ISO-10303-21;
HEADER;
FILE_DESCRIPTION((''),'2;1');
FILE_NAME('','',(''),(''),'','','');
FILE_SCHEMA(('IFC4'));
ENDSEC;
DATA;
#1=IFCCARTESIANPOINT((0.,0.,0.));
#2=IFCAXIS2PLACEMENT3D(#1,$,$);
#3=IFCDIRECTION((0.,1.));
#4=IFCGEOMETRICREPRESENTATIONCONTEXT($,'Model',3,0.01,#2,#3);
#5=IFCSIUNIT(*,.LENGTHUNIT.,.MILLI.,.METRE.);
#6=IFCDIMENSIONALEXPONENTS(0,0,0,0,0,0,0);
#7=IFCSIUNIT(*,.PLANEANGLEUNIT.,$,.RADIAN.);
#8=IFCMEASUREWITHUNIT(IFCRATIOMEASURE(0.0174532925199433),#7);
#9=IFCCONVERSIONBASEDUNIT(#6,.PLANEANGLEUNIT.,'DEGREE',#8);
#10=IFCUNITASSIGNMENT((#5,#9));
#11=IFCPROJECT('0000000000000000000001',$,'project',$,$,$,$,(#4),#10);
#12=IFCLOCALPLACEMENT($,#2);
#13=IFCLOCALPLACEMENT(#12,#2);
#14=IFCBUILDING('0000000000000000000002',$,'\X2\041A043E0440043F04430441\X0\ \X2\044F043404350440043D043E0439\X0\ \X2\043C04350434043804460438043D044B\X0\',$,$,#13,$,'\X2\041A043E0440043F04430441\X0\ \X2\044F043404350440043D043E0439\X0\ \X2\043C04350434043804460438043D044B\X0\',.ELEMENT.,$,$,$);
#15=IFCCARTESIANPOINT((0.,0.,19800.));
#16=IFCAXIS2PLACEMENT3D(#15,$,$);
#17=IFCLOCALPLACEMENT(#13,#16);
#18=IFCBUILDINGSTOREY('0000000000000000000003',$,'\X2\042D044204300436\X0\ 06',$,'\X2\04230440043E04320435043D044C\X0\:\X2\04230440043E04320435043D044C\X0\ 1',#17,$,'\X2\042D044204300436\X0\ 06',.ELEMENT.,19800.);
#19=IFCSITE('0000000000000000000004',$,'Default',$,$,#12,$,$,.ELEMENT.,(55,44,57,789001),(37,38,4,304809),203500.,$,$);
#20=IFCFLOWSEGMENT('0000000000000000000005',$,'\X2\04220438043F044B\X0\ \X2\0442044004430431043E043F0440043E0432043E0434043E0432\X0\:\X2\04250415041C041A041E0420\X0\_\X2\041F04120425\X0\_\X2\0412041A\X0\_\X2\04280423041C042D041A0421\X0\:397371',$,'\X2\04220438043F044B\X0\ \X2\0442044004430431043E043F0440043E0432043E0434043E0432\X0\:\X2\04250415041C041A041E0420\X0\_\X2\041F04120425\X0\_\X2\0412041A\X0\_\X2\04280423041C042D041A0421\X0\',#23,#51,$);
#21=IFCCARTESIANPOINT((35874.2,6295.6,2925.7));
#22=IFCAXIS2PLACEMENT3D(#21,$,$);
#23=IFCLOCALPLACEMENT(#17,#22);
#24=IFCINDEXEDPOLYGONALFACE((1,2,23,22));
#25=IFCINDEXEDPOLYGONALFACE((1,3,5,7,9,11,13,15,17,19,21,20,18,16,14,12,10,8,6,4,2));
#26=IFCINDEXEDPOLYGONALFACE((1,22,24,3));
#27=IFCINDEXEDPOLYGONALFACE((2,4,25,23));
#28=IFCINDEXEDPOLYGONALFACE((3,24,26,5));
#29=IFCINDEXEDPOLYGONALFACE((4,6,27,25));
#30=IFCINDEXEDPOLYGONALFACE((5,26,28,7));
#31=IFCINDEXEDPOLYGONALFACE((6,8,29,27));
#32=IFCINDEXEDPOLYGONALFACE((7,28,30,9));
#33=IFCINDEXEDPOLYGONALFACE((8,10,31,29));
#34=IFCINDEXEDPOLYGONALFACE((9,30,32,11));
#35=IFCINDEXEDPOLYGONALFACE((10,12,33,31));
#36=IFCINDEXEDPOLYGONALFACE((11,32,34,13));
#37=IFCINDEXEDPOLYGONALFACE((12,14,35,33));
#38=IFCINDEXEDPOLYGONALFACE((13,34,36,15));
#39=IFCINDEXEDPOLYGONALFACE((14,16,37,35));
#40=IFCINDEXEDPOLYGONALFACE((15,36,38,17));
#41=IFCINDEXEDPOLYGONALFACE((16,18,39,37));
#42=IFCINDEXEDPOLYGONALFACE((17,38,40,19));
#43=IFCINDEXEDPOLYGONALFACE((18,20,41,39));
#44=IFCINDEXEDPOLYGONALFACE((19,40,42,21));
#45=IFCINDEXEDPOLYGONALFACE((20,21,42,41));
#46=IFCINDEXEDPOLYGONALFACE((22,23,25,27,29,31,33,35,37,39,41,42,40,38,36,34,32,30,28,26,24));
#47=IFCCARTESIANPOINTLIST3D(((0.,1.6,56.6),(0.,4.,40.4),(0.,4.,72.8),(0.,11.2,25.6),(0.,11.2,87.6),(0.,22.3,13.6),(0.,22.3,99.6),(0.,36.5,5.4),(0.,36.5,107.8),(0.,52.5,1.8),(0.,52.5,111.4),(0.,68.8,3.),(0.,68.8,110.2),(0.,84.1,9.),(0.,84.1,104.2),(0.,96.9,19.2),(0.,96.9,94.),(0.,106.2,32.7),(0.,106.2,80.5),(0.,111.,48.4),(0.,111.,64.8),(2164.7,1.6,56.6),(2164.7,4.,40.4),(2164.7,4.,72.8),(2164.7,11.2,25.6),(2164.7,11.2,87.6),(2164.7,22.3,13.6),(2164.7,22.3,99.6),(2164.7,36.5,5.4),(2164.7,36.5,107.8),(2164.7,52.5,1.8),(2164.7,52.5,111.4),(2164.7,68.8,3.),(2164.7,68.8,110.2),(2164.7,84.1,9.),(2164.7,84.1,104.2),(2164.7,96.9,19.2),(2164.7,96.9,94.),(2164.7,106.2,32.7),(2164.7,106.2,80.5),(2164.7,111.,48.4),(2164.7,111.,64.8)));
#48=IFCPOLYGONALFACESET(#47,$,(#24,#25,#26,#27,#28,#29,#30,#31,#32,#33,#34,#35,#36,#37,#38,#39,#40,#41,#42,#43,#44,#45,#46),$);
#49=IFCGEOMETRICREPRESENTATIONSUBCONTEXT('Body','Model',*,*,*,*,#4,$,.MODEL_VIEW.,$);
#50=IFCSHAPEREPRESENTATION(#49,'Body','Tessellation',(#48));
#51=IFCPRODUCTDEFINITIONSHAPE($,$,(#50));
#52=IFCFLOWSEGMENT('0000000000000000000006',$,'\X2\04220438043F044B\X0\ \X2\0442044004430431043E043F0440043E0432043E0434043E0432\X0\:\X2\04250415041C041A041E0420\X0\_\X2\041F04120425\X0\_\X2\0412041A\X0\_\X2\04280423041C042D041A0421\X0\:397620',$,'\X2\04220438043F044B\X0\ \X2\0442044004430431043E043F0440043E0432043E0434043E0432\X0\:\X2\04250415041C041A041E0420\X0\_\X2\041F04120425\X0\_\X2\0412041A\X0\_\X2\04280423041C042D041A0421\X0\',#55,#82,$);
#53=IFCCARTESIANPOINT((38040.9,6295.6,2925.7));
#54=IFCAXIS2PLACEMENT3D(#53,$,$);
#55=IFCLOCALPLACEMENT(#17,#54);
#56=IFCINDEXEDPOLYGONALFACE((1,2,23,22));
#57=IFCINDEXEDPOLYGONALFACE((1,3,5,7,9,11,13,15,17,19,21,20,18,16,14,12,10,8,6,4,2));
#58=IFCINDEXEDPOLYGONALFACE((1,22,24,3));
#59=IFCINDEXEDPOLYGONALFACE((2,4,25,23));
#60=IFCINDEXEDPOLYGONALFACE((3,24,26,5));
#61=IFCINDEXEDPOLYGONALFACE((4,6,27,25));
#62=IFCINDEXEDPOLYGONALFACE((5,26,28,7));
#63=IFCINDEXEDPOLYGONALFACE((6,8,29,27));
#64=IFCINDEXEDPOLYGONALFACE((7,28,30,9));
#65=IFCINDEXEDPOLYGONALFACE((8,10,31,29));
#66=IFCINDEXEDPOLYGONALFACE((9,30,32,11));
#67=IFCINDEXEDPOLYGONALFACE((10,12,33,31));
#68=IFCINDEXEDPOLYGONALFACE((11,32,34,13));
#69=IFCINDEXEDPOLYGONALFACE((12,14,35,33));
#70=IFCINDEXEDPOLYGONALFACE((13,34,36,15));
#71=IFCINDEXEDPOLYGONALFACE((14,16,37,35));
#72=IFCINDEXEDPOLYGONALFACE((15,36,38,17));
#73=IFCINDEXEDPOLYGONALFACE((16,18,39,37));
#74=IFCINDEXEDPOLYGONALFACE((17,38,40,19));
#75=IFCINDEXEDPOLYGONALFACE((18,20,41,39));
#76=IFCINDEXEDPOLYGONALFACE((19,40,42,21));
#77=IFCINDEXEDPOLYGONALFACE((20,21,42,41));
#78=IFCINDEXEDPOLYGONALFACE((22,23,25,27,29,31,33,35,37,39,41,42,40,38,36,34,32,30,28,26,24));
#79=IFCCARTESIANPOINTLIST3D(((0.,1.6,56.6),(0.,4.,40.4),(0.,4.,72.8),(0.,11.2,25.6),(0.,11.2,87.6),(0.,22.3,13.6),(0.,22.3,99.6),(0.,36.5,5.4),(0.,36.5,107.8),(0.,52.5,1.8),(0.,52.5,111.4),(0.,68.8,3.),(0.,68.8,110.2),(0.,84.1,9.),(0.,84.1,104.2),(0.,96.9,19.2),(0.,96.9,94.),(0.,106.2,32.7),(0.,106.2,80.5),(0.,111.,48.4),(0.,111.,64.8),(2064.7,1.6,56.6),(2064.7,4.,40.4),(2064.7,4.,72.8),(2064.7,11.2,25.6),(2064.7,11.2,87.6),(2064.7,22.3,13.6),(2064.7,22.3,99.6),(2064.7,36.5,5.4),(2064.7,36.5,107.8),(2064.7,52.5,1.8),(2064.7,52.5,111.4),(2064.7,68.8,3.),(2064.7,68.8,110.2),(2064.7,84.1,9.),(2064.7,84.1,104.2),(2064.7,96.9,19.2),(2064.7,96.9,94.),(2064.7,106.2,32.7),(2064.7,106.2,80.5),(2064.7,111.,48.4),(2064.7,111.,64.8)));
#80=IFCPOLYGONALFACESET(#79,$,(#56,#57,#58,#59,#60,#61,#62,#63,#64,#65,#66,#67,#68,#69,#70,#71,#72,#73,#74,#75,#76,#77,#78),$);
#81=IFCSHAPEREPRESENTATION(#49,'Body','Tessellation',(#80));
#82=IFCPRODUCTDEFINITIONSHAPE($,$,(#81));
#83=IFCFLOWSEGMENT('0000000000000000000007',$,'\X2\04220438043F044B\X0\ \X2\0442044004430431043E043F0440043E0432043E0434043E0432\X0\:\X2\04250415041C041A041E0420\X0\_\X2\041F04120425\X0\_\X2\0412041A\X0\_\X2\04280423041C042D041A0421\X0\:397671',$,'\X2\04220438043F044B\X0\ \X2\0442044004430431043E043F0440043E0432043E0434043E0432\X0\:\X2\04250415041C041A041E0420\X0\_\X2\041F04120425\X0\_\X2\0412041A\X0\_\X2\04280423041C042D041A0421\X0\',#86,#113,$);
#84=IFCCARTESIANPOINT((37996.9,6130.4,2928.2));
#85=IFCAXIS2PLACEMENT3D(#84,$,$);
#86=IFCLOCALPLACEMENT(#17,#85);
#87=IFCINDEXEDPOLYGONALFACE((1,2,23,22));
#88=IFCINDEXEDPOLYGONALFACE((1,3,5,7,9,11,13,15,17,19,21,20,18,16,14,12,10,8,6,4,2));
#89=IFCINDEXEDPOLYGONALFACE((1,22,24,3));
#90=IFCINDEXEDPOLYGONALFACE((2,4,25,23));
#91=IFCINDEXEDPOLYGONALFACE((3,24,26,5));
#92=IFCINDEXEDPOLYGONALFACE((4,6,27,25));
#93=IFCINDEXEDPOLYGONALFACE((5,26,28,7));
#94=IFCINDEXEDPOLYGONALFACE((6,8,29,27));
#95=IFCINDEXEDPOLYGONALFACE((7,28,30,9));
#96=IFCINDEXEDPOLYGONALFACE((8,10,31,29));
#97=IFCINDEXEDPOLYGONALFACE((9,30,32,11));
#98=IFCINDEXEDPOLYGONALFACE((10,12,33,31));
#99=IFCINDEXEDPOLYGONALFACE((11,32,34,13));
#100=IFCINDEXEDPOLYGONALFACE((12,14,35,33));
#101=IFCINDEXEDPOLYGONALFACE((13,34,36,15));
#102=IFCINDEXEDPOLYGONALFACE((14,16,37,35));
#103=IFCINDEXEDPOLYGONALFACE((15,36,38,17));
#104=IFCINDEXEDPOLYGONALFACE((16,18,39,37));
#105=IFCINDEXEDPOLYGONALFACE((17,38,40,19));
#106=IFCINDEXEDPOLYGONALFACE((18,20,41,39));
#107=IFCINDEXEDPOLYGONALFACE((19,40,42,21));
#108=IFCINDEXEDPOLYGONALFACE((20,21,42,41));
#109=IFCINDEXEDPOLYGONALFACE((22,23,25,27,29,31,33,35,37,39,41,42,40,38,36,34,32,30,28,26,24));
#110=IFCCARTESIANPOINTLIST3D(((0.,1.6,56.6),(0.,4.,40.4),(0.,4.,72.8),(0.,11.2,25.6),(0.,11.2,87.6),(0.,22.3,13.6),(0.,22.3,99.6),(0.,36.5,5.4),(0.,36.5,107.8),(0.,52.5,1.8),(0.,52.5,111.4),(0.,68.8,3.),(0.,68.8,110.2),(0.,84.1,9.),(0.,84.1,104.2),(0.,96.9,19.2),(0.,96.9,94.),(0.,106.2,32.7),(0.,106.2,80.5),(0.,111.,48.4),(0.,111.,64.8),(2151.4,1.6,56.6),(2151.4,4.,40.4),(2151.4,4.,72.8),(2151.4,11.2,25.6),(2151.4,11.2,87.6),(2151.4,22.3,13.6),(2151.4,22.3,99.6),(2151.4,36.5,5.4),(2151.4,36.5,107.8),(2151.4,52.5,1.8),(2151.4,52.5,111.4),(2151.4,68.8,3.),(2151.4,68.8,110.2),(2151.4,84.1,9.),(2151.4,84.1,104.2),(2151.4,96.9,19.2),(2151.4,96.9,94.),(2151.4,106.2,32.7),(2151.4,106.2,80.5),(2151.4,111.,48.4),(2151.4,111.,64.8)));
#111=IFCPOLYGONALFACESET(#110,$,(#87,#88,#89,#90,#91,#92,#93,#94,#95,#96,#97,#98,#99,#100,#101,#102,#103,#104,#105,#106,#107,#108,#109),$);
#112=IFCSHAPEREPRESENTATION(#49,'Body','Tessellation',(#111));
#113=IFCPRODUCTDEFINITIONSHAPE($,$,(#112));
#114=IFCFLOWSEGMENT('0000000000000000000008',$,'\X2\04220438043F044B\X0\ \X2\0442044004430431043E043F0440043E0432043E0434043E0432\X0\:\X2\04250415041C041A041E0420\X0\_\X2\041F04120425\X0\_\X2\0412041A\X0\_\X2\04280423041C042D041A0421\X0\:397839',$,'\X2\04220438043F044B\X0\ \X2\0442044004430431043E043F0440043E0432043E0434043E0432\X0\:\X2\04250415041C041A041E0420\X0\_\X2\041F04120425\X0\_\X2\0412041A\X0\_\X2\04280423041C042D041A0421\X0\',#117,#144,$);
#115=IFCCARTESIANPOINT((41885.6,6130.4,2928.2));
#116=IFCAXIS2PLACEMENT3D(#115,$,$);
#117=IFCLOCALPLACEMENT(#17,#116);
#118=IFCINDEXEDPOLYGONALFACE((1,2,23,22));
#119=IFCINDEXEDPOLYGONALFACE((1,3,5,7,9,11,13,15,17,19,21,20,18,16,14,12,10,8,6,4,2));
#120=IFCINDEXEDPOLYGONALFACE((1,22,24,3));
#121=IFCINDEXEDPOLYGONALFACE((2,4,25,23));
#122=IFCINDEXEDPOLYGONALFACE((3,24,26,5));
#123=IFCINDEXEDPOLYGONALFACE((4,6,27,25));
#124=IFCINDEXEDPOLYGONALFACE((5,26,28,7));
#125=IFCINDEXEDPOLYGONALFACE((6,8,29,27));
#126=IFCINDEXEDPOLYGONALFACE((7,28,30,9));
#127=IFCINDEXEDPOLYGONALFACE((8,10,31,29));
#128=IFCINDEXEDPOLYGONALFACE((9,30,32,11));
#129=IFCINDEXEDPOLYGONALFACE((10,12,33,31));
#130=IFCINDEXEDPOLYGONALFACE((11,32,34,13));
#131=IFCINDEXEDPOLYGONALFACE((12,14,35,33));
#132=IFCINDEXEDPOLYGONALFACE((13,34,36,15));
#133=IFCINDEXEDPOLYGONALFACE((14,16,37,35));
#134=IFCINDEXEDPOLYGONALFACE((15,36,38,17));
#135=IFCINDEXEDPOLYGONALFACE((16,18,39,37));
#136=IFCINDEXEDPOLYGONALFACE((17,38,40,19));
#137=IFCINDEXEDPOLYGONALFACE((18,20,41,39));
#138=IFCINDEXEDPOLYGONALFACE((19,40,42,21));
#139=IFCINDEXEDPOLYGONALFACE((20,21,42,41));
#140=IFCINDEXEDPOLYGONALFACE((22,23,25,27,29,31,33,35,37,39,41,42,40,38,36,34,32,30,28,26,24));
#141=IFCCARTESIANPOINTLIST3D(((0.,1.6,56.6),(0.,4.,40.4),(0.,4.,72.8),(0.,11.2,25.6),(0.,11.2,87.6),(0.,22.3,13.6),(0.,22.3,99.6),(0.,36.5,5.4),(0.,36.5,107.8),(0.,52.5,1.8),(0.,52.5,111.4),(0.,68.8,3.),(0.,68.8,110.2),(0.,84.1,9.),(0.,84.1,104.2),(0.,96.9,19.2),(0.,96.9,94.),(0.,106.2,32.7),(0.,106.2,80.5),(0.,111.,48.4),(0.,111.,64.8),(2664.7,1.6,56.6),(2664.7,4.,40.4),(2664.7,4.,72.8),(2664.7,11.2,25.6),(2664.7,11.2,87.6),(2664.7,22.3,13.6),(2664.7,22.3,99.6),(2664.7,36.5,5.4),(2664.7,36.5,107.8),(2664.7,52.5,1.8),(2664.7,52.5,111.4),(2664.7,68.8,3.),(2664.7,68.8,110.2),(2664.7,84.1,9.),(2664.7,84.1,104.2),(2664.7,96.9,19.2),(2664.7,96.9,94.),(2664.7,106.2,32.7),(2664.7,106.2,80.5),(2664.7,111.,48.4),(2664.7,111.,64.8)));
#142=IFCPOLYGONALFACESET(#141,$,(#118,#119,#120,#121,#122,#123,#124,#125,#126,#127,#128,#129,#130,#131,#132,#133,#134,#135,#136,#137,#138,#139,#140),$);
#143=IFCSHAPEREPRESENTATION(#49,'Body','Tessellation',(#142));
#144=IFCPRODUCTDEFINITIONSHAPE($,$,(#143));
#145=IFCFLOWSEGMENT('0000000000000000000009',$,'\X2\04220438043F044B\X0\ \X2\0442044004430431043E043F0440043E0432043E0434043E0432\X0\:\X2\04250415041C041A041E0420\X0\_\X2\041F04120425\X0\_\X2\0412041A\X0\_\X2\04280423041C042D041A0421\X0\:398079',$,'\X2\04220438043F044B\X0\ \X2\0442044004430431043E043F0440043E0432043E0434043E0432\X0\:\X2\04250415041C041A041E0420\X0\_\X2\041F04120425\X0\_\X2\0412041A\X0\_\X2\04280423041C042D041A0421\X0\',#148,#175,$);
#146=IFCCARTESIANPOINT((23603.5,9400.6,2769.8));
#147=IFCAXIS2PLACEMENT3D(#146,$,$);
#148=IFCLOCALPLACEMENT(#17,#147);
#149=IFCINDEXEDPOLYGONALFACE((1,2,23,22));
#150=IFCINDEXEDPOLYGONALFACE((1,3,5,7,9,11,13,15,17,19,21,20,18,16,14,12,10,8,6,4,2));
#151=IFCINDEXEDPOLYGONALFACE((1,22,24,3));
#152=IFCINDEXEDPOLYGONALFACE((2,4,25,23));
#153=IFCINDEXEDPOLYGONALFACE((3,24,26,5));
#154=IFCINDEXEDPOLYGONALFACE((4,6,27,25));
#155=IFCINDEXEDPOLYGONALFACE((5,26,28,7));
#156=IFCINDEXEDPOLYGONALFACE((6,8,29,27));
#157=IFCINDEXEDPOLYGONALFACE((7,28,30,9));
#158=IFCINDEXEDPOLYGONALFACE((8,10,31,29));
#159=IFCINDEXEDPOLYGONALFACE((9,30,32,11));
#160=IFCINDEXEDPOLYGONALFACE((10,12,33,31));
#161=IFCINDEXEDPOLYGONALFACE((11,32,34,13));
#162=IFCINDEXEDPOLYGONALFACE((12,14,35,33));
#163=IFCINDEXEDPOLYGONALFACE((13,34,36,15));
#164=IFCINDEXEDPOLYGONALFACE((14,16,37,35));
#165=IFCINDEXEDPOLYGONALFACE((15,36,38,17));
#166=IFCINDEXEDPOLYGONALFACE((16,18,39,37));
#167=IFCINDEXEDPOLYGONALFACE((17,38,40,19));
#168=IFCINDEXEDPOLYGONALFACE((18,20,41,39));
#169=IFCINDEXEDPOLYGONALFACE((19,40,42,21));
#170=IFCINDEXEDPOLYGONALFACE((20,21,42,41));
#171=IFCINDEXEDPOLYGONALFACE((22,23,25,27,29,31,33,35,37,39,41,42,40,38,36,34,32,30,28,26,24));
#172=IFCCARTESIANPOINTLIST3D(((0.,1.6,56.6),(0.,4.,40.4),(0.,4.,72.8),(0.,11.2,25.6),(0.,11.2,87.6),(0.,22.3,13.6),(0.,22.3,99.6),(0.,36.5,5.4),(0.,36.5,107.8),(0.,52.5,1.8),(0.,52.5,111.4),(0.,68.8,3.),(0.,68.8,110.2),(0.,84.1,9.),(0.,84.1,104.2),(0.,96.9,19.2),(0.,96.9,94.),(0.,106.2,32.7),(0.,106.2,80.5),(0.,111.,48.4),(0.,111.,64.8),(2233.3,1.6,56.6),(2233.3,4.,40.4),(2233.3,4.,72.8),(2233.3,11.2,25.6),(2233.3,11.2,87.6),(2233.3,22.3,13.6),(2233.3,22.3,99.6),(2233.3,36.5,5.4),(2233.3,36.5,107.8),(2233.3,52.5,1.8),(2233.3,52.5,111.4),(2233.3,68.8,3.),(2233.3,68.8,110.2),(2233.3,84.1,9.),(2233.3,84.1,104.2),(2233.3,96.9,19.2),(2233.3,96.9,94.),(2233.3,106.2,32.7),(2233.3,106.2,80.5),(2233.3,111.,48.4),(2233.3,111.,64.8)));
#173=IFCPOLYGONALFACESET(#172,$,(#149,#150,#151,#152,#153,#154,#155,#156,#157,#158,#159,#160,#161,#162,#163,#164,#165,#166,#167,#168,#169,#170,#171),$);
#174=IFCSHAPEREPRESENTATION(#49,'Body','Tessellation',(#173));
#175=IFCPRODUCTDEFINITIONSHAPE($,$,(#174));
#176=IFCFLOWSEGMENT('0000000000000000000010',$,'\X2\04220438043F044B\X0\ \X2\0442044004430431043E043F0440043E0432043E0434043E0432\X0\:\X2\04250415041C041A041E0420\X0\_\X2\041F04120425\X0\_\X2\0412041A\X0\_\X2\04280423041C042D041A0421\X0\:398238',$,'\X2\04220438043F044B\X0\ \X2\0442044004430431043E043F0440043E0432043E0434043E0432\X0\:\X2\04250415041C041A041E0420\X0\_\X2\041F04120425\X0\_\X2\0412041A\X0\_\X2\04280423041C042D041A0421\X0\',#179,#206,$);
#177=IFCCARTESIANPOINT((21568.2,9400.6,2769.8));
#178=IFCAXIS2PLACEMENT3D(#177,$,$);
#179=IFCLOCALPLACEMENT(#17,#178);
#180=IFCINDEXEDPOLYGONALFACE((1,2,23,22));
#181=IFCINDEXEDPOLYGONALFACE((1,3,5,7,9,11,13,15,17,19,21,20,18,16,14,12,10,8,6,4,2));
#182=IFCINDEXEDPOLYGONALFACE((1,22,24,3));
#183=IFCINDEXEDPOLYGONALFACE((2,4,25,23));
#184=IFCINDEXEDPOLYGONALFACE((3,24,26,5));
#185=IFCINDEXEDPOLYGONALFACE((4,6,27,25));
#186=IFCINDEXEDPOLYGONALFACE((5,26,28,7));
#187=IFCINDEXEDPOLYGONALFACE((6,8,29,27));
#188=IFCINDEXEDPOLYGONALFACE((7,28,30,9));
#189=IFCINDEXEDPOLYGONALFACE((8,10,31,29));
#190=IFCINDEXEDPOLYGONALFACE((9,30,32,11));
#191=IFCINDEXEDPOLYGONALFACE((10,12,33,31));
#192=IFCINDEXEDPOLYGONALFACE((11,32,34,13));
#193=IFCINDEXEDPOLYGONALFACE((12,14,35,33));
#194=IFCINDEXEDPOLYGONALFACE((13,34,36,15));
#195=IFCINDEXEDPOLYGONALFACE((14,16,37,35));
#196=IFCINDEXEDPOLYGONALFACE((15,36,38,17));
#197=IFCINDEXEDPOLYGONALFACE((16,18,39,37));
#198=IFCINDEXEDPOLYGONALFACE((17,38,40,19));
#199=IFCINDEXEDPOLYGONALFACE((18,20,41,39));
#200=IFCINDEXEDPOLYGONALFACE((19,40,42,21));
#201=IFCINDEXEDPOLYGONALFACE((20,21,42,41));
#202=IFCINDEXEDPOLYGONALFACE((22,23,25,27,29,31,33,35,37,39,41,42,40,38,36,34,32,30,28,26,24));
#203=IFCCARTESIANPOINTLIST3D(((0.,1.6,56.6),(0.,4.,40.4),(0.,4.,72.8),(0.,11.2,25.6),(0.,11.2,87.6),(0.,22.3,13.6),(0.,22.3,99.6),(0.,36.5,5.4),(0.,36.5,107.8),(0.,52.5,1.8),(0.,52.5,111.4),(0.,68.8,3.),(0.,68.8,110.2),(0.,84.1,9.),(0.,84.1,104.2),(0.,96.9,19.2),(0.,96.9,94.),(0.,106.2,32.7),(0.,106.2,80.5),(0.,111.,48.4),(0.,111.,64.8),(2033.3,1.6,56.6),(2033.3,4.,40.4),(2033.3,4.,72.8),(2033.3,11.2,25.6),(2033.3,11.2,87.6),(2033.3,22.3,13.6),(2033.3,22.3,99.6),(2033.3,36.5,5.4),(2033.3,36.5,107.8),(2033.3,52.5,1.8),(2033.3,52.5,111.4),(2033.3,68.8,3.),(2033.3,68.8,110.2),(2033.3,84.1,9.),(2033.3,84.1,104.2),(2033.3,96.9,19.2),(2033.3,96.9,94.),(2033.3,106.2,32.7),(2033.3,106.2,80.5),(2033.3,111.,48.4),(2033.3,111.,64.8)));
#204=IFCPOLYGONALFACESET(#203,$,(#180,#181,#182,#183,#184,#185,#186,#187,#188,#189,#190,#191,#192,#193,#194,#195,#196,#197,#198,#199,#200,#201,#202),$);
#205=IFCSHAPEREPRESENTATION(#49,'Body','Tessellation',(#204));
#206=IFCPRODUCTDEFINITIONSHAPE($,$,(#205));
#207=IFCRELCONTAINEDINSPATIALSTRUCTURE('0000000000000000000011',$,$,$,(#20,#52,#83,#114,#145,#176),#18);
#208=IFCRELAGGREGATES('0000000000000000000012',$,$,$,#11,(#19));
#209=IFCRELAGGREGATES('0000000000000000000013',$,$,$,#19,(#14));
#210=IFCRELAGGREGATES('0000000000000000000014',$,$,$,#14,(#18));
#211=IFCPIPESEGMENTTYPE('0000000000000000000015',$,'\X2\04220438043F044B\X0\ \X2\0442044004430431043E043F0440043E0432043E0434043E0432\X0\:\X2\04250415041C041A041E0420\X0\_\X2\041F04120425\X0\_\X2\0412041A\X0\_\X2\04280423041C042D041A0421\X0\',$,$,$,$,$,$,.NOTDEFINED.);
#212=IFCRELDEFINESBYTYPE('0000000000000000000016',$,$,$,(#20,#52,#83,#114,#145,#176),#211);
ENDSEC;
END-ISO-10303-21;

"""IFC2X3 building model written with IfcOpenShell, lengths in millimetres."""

from ifc_helpers import new_model, entity, si_unit, converted_unit, direction, frame, origin, origin_2d_with_axis, place, context, subcontext, project, spatial, circle, extrude, type_object, element, save


model = new_model("IFC2X3")

# Units and contexts
model_context = context("Model", 3, precision=0.01, world=origin(), true_north=direction((0.0, 1.0)))
body_context = subcontext(model_context, "Body", "Model", "MODEL_VIEW")
ifc_project = project(units=[si_unit("LENGTHUNIT", "METRE", prefix="MILLI"), converted_unit("PLANEANGLEUNIT", "DEGREE", entity("IfcRatioMeasure", 0.0174532925199433), si_unit("PLANEANGLEUNIT", "RADIAN"), dimensions=[0, 0, 0, 0, 0, 0, 0])], contexts=[model_context])

# Site, building, storey
site_placement = place(None, origin())
site = spatial("IfcSite", under=ifc_project, at=site_placement, Name="Default", CompositionType="ELEMENT", RefLatitude=(55, 44, 57, 789001), RefLongitude=(37, 38, 4, 304809), RefElevation=203500.0)
building_placement = place(site_placement, origin())
building = spatial("IfcBuilding", under=site, at=building_placement, Name="Корпус ядерной медицины", LongName="Корпус ядерной медицины", CompositionType="ELEMENT")
storey_placement = place(building_placement, frame((0.0, 0.0, 19800.0)))
storey = spatial("IfcBuildingStorey", under=building, at=storey_placement, Name="Этаж 06", ObjectType="Уровень:Уровень 1", LongName="Этаж 06", CompositionType="ELEMENT", Elevation=19800.0)

# Flow segments
pipe_segment_type = type_object("IfcPipeSegmentType", Name="Типы трубопроводов:ХЕМКОР_ПВХ_ВК_ШУМЭКС", PredefinedType="NOTDEFINED")
flow_segment_1_placement = place(storey_placement, frame((35874.2, 6295.6, 2925.7)))
element("IfcFlowSegment", 1, at=flow_segment_1_placement, inside=storey, type_object=pipe_segment_type, Name="Типы трубопроводов:ХЕМКОР_ПВХ_ВК_ШУМЭКС:397371", ObjectType="Типы трубопроводов:ХЕМКОР_ПВХ_ВК_ШУМЭКС", context=body_context, shape_type="SweptSolid", body=[
    extrude(circle(Radius=55.0, at=origin_2d_with_axis()), frame((0.0, 56.6, 56.6), z_axis=(1.0, 0.0, 0.0), x_axis=(0.0, -1.0, 0.0)), (0.0, 0.0, 1.0), 2164.7),
])
flow_segment_2_placement = place(storey_placement, frame((38040.9, 6295.6, 2925.7)))
element("IfcFlowSegment", 2, at=flow_segment_2_placement, inside=storey, type_object=pipe_segment_type, Name="Типы трубопроводов:ХЕМКОР_ПВХ_ВК_ШУМЭКС:397620", ObjectType="Типы трубопроводов:ХЕМКОР_ПВХ_ВК_ШУМЭКС", context=body_context, shape_type="SweptSolid", body=[
    extrude(circle(Radius=55.0, at=origin_2d_with_axis()), frame((0.0, 56.6, 56.6), z_axis=(1.0, 0.0, 0.0), x_axis=(0.0, -1.0, 0.0)), (0.0, 0.0, 1.0), 2064.7),
])
flow_segment_3_placement = place(storey_placement, frame((37996.9, 6130.4, 2928.2)))
element("IfcFlowSegment", 3, at=flow_segment_3_placement, inside=storey, type_object=pipe_segment_type, Name="Типы трубопроводов:ХЕМКОР_ПВХ_ВК_ШУМЭКС:397671", ObjectType="Типы трубопроводов:ХЕМКОР_ПВХ_ВК_ШУМЭКС", context=body_context, shape_type="SweptSolid", body=[
    extrude(circle(Radius=55.0, at=origin_2d_with_axis()), frame((0.0, 56.6, 56.6), z_axis=(1.0, 0.0, 0.0), x_axis=(0.0, -1.0, 0.0)), (0.0, 0.0, 1.0), 2151.4),
])
flow_segment_4_placement = place(storey_placement, frame((41885.6, 6130.4, 2928.2)))
element("IfcFlowSegment", 4, at=flow_segment_4_placement, inside=storey, type_object=pipe_segment_type, Name="Типы трубопроводов:ХЕМКОР_ПВХ_ВК_ШУМЭКС:397839", ObjectType="Типы трубопроводов:ХЕМКОР_ПВХ_ВК_ШУМЭКС", context=body_context, shape_type="SweptSolid", body=[
    extrude(circle(Radius=55.0, at=origin_2d_with_axis()), frame((0.0, 56.6, 56.6), z_axis=(1.0, 0.0, 0.0), x_axis=(0.0, -1.0, 0.0)), (0.0, 0.0, 1.0), 2664.7),
])
flow_segment_5_placement = place(storey_placement, frame((23603.5, 9400.6, 2769.8)))
element("IfcFlowSegment", 5, at=flow_segment_5_placement, inside=storey, type_object=pipe_segment_type, Name="Типы трубопроводов:ХЕМКОР_ПВХ_ВК_ШУМЭКС:398079", ObjectType="Типы трубопроводов:ХЕМКОР_ПВХ_ВК_ШУМЭКС", context=body_context, shape_type="SweptSolid", body=[
    extrude(circle(Radius=55.0, at=origin_2d_with_axis()), frame((0.0, 56.6, 56.6), z_axis=(1.0, 0.0, 0.0), x_axis=(0.0, -1.0, 0.0)), (0.0, 0.0, 1.0), 2233.3),
])
flow_segment_6_placement = place(storey_placement, frame((21568.2, 9400.6, 2769.8)))
element("IfcFlowSegment", 6, at=flow_segment_6_placement, inside=storey, type_object=pipe_segment_type, Name="Типы трубопроводов:ХЕМКОР_ПВХ_ВК_ШУМЭКС:398238", ObjectType="Типы трубопроводов:ХЕМКОР_ПВХ_ВК_ШУМЭКС", context=body_context, shape_type="SweptSolid", body=[
    extrude(circle(Radius=55.0, at=origin_2d_with_axis()), frame((0.0, 56.6, 56.6), z_axis=(1.0, 0.0, 0.0), x_axis=(0.0, -1.0, 0.0)), (0.0, 0.0, 1.0), 2033.3),
])

save(model, "model.ifc")
